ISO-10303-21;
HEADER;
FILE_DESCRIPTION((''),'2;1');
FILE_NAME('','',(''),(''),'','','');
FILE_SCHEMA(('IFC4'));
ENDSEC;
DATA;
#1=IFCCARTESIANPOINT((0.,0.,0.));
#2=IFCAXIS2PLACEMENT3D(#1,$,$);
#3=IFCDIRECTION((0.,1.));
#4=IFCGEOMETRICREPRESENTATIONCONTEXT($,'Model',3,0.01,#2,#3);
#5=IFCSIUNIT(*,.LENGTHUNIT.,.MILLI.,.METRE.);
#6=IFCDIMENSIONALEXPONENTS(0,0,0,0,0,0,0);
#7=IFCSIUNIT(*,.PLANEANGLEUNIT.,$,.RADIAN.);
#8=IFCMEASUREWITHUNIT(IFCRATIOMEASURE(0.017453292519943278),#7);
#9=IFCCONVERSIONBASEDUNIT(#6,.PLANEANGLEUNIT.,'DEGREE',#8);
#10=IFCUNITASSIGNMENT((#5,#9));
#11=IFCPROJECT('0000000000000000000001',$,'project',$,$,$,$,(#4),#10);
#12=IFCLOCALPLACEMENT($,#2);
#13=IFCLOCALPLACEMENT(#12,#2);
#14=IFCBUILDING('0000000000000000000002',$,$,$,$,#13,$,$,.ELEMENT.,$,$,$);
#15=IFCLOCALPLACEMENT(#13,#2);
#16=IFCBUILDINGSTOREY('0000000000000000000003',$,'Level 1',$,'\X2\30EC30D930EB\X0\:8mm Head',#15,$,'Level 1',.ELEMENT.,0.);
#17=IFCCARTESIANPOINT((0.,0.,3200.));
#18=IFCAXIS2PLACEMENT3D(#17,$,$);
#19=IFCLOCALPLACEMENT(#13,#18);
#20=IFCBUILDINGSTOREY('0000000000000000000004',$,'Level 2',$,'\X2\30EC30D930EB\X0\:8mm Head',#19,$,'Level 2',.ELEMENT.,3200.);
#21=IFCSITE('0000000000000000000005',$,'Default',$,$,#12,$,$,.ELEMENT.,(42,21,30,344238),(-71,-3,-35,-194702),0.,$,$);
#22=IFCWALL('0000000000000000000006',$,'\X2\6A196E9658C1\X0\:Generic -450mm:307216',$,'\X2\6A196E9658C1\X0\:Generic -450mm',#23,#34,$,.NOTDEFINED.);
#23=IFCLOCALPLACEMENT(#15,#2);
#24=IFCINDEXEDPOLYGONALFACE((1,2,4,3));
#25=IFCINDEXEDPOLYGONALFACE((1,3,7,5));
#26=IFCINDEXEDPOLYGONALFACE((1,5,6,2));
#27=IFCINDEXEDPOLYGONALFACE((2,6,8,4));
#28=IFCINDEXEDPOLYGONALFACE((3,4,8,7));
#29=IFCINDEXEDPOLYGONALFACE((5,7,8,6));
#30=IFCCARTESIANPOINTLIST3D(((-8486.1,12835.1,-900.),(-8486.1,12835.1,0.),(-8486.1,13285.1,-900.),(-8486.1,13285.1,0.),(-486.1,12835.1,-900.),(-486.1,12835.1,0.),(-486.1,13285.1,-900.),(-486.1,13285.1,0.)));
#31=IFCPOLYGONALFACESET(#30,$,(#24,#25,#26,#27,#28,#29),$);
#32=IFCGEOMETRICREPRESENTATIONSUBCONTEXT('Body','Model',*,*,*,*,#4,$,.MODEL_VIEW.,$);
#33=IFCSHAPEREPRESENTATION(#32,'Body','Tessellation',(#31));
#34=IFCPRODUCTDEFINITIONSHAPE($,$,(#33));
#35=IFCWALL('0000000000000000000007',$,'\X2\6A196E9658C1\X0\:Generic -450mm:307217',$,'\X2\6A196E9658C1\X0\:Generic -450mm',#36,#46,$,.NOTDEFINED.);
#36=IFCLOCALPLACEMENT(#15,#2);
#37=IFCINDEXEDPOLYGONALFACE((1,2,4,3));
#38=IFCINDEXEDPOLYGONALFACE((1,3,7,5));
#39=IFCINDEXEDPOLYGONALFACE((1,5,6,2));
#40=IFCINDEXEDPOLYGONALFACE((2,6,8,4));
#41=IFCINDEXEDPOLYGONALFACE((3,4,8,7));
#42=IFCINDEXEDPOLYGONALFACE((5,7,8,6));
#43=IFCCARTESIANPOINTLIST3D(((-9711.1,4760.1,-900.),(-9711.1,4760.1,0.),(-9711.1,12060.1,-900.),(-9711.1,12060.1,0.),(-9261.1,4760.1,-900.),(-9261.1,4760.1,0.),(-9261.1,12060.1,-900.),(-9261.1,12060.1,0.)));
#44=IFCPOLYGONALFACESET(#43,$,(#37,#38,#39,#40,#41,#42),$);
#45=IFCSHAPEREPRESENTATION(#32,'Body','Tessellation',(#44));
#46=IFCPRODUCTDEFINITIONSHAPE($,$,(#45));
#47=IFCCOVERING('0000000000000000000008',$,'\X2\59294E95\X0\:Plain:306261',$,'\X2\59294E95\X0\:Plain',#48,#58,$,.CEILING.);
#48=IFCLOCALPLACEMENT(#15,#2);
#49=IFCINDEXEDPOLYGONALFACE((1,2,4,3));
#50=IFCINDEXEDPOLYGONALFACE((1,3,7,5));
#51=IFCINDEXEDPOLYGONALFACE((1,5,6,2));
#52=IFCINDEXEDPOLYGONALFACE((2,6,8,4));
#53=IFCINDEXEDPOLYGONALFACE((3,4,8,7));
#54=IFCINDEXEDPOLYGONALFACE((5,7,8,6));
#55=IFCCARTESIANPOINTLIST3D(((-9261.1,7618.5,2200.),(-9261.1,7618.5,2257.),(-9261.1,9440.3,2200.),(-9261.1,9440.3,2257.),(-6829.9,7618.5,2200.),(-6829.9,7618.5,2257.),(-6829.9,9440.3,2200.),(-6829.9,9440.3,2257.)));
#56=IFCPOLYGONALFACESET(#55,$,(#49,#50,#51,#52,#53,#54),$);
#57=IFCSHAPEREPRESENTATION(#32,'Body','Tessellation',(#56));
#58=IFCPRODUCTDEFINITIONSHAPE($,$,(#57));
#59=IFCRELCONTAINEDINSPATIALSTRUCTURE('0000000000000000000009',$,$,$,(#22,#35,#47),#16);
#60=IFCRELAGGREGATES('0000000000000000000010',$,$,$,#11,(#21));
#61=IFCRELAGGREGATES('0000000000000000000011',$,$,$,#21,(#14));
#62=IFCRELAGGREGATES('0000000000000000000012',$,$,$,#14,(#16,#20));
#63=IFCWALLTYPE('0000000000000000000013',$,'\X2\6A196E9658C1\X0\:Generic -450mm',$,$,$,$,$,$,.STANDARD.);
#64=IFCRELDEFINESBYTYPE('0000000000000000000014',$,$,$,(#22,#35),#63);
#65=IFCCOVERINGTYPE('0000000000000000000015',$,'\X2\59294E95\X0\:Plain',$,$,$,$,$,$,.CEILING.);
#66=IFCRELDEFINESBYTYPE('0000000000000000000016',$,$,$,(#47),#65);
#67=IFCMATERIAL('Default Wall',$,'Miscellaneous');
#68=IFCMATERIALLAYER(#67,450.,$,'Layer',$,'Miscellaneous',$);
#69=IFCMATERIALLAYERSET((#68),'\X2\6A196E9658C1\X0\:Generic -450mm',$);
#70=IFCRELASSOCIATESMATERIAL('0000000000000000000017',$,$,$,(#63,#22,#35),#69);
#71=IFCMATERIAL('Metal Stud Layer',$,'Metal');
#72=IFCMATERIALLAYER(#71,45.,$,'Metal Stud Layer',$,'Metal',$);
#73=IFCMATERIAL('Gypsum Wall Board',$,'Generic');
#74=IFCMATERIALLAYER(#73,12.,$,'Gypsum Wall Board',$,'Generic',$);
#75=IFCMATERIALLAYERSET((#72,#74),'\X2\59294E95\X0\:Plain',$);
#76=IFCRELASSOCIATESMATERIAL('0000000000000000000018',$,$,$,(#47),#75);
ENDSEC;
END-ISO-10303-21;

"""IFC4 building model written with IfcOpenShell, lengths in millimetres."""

from ifc_helpers import new_model, entity, si_unit, converted_unit, direction, frame, frame_2d, origin, place, context, subcontext, project, spatial, rectangle, extrude, material, layer, layer_set, layer_usage, type_object, element, save


model = new_model("IFC4")

# Units and contexts
model_context = context("Model", 3, precision=0.01, world=origin(), true_north=direction((0.0, 1.0)))
body_context = subcontext(model_context, "Body", "Model", "MODEL_VIEW")
ifc_project = project(units=[si_unit("LENGTHUNIT", "METRE", prefix="MILLI"), converted_unit("PLANEANGLEUNIT", "DEGREE", entity("IfcRatioMeasure", 0.017453292519943278), si_unit("PLANEANGLEUNIT", "RADIAN"), dimensions=[0, 0, 0, 0, 0, 0, 0])], contexts=[model_context])

# Site, building, storey
site_placement = place(None, origin())
site = spatial("IfcSite", under=ifc_project, at=site_placement, Name="Default", CompositionType="ELEMENT", RefLatitude=(42, 21, 30, 344238), RefLongitude=(-71, -3, -35, -194702), RefElevation=0.0)
building_placement = place(site_placement, origin())
building = spatial("IfcBuilding", under=site, at=building_placement, CompositionType="ELEMENT")
storey_1_placement = place(building_placement, origin())
storey_1 = spatial("IfcBuildingStorey", under=building, at=storey_1_placement, Name="Level 1", ObjectType="レベル:8mm Head", LongName="Level 1", CompositionType="ELEMENT", Elevation=0.0)

# Shared definitions
ifc_material_1 = material(Name="Default Wall", Category="Miscellaneous")
ifc_layer_1 = layer(ifc_material_1, 450.0, Name="Layer", Category="Miscellaneous")
ifc_layer_set_1 = layer_set([ifc_layer_1], Name="標準壁:Generic -450mm")
wall_type = type_object("IfcWallType", Name="標準壁:Generic -450mm", PredefinedType="STANDARD", material=ifc_layer_set_1)

# Shared definitions
storey_2_placement = place(building_placement, frame((0.0, 0.0, 3200.0)))
storey_2 = spatial("IfcBuildingStorey", under=building, at=storey_2_placement, Name="Level 2", ObjectType="レベル:8mm Head", LongName="Level 2", CompositionType="ELEMENT", Elevation=3200.0)

# Walls
ifc_layer_usage_1 = layer_usage(ifc_layer_set_1, "AXIS2", "NEGATIVE", 225.0)
wall_1_placement = place(storey_1_placement, frame((-8486.1, 13060.1, -900.0)))
element("IfcWall", 1, at=wall_1_placement, inside=storey_1, type_object=wall_type, material=ifc_layer_usage_1, Name="標準壁:Generic -450mm:307216", ObjectType="標準壁:Generic -450mm", PredefinedType="NOTDEFINED", context=body_context, shape_type="SweptSolid", body=[
    extrude(rectangle(XDim=8000.0, YDim=450.0, at=frame_2d((4000.0, 0.0), x_axis=(-1.0, 0.0))), origin(), (0.0, 0.0, 1.0), 900.0),
])
ifc_layer_usage_2 = layer_usage(ifc_layer_set_1, "AXIS2", "NEGATIVE", 225.0)
wall_2_placement = place(storey_1_placement, frame((-9486.1, 4760.1, -900.0), z_axis=(0.0, 0.0, 1.0), x_axis=(0.0, 1.0, 0.0)))
element("IfcWall", 2, at=wall_2_placement, inside=storey_1, type_object=wall_type, material=ifc_layer_usage_2, Name="標準壁:Generic -450mm:307217", ObjectType="標準壁:Generic -450mm", PredefinedType="NOTDEFINED", context=body_context, shape_type="SweptSolid", body=[
    extrude(rectangle(XDim=7300.0, YDim=450.0, at=frame_2d((3650.0, 0.0), x_axis=(-1.0, 0.0))), origin(), (0.0, 0.0, 1.0), 900.0),
])

# Covering
ifc_material_2 = material(Name="Metal Stud Layer", Category="Metal")
ifc_layer_2 = layer(ifc_material_2, 45.0, Name="Metal Stud Layer", Category="Metal")
ifc_material_3 = material(Name="Gypsum Wall Board", Category="Generic")
ifc_layer_3 = layer(ifc_material_3, 12.0, Name="Gypsum Wall Board", Category="Generic")
ifc_layer_set_2 = layer_set([ifc_layer_2, ifc_layer_3], Name="天井:Plain")
ifc_layer_usage_3 = layer_usage(ifc_layer_set_2, "AXIS3", "POSITIVE", 0.0)
covering_type_1 = type_object("IfcCoveringType", Name="天井:Plain", PredefinedType="CEILING")
covering_1_placement = place(storey_1_placement, frame((-9261.1, 7618.5, 2200.0)))
element("IfcCovering", 3, at=covering_1_placement, inside=storey_1, type_object=covering_type_1, material=ifc_layer_usage_3, Name="天井:Plain:306261", ObjectType="天井:Plain", PredefinedType="CEILING", context=body_context, shape_type="SweptSolid", body=[
    extrude(rectangle(XDim=2431.2, YDim=1821.8, at=frame_2d((0.0, 0.0), x_axis=(1.0, 0.0))), frame((1215.6, 910.9, 0.0)), (0.0, 0.0, 1.0), 57.0),
])

save(model, "model.ifc")
